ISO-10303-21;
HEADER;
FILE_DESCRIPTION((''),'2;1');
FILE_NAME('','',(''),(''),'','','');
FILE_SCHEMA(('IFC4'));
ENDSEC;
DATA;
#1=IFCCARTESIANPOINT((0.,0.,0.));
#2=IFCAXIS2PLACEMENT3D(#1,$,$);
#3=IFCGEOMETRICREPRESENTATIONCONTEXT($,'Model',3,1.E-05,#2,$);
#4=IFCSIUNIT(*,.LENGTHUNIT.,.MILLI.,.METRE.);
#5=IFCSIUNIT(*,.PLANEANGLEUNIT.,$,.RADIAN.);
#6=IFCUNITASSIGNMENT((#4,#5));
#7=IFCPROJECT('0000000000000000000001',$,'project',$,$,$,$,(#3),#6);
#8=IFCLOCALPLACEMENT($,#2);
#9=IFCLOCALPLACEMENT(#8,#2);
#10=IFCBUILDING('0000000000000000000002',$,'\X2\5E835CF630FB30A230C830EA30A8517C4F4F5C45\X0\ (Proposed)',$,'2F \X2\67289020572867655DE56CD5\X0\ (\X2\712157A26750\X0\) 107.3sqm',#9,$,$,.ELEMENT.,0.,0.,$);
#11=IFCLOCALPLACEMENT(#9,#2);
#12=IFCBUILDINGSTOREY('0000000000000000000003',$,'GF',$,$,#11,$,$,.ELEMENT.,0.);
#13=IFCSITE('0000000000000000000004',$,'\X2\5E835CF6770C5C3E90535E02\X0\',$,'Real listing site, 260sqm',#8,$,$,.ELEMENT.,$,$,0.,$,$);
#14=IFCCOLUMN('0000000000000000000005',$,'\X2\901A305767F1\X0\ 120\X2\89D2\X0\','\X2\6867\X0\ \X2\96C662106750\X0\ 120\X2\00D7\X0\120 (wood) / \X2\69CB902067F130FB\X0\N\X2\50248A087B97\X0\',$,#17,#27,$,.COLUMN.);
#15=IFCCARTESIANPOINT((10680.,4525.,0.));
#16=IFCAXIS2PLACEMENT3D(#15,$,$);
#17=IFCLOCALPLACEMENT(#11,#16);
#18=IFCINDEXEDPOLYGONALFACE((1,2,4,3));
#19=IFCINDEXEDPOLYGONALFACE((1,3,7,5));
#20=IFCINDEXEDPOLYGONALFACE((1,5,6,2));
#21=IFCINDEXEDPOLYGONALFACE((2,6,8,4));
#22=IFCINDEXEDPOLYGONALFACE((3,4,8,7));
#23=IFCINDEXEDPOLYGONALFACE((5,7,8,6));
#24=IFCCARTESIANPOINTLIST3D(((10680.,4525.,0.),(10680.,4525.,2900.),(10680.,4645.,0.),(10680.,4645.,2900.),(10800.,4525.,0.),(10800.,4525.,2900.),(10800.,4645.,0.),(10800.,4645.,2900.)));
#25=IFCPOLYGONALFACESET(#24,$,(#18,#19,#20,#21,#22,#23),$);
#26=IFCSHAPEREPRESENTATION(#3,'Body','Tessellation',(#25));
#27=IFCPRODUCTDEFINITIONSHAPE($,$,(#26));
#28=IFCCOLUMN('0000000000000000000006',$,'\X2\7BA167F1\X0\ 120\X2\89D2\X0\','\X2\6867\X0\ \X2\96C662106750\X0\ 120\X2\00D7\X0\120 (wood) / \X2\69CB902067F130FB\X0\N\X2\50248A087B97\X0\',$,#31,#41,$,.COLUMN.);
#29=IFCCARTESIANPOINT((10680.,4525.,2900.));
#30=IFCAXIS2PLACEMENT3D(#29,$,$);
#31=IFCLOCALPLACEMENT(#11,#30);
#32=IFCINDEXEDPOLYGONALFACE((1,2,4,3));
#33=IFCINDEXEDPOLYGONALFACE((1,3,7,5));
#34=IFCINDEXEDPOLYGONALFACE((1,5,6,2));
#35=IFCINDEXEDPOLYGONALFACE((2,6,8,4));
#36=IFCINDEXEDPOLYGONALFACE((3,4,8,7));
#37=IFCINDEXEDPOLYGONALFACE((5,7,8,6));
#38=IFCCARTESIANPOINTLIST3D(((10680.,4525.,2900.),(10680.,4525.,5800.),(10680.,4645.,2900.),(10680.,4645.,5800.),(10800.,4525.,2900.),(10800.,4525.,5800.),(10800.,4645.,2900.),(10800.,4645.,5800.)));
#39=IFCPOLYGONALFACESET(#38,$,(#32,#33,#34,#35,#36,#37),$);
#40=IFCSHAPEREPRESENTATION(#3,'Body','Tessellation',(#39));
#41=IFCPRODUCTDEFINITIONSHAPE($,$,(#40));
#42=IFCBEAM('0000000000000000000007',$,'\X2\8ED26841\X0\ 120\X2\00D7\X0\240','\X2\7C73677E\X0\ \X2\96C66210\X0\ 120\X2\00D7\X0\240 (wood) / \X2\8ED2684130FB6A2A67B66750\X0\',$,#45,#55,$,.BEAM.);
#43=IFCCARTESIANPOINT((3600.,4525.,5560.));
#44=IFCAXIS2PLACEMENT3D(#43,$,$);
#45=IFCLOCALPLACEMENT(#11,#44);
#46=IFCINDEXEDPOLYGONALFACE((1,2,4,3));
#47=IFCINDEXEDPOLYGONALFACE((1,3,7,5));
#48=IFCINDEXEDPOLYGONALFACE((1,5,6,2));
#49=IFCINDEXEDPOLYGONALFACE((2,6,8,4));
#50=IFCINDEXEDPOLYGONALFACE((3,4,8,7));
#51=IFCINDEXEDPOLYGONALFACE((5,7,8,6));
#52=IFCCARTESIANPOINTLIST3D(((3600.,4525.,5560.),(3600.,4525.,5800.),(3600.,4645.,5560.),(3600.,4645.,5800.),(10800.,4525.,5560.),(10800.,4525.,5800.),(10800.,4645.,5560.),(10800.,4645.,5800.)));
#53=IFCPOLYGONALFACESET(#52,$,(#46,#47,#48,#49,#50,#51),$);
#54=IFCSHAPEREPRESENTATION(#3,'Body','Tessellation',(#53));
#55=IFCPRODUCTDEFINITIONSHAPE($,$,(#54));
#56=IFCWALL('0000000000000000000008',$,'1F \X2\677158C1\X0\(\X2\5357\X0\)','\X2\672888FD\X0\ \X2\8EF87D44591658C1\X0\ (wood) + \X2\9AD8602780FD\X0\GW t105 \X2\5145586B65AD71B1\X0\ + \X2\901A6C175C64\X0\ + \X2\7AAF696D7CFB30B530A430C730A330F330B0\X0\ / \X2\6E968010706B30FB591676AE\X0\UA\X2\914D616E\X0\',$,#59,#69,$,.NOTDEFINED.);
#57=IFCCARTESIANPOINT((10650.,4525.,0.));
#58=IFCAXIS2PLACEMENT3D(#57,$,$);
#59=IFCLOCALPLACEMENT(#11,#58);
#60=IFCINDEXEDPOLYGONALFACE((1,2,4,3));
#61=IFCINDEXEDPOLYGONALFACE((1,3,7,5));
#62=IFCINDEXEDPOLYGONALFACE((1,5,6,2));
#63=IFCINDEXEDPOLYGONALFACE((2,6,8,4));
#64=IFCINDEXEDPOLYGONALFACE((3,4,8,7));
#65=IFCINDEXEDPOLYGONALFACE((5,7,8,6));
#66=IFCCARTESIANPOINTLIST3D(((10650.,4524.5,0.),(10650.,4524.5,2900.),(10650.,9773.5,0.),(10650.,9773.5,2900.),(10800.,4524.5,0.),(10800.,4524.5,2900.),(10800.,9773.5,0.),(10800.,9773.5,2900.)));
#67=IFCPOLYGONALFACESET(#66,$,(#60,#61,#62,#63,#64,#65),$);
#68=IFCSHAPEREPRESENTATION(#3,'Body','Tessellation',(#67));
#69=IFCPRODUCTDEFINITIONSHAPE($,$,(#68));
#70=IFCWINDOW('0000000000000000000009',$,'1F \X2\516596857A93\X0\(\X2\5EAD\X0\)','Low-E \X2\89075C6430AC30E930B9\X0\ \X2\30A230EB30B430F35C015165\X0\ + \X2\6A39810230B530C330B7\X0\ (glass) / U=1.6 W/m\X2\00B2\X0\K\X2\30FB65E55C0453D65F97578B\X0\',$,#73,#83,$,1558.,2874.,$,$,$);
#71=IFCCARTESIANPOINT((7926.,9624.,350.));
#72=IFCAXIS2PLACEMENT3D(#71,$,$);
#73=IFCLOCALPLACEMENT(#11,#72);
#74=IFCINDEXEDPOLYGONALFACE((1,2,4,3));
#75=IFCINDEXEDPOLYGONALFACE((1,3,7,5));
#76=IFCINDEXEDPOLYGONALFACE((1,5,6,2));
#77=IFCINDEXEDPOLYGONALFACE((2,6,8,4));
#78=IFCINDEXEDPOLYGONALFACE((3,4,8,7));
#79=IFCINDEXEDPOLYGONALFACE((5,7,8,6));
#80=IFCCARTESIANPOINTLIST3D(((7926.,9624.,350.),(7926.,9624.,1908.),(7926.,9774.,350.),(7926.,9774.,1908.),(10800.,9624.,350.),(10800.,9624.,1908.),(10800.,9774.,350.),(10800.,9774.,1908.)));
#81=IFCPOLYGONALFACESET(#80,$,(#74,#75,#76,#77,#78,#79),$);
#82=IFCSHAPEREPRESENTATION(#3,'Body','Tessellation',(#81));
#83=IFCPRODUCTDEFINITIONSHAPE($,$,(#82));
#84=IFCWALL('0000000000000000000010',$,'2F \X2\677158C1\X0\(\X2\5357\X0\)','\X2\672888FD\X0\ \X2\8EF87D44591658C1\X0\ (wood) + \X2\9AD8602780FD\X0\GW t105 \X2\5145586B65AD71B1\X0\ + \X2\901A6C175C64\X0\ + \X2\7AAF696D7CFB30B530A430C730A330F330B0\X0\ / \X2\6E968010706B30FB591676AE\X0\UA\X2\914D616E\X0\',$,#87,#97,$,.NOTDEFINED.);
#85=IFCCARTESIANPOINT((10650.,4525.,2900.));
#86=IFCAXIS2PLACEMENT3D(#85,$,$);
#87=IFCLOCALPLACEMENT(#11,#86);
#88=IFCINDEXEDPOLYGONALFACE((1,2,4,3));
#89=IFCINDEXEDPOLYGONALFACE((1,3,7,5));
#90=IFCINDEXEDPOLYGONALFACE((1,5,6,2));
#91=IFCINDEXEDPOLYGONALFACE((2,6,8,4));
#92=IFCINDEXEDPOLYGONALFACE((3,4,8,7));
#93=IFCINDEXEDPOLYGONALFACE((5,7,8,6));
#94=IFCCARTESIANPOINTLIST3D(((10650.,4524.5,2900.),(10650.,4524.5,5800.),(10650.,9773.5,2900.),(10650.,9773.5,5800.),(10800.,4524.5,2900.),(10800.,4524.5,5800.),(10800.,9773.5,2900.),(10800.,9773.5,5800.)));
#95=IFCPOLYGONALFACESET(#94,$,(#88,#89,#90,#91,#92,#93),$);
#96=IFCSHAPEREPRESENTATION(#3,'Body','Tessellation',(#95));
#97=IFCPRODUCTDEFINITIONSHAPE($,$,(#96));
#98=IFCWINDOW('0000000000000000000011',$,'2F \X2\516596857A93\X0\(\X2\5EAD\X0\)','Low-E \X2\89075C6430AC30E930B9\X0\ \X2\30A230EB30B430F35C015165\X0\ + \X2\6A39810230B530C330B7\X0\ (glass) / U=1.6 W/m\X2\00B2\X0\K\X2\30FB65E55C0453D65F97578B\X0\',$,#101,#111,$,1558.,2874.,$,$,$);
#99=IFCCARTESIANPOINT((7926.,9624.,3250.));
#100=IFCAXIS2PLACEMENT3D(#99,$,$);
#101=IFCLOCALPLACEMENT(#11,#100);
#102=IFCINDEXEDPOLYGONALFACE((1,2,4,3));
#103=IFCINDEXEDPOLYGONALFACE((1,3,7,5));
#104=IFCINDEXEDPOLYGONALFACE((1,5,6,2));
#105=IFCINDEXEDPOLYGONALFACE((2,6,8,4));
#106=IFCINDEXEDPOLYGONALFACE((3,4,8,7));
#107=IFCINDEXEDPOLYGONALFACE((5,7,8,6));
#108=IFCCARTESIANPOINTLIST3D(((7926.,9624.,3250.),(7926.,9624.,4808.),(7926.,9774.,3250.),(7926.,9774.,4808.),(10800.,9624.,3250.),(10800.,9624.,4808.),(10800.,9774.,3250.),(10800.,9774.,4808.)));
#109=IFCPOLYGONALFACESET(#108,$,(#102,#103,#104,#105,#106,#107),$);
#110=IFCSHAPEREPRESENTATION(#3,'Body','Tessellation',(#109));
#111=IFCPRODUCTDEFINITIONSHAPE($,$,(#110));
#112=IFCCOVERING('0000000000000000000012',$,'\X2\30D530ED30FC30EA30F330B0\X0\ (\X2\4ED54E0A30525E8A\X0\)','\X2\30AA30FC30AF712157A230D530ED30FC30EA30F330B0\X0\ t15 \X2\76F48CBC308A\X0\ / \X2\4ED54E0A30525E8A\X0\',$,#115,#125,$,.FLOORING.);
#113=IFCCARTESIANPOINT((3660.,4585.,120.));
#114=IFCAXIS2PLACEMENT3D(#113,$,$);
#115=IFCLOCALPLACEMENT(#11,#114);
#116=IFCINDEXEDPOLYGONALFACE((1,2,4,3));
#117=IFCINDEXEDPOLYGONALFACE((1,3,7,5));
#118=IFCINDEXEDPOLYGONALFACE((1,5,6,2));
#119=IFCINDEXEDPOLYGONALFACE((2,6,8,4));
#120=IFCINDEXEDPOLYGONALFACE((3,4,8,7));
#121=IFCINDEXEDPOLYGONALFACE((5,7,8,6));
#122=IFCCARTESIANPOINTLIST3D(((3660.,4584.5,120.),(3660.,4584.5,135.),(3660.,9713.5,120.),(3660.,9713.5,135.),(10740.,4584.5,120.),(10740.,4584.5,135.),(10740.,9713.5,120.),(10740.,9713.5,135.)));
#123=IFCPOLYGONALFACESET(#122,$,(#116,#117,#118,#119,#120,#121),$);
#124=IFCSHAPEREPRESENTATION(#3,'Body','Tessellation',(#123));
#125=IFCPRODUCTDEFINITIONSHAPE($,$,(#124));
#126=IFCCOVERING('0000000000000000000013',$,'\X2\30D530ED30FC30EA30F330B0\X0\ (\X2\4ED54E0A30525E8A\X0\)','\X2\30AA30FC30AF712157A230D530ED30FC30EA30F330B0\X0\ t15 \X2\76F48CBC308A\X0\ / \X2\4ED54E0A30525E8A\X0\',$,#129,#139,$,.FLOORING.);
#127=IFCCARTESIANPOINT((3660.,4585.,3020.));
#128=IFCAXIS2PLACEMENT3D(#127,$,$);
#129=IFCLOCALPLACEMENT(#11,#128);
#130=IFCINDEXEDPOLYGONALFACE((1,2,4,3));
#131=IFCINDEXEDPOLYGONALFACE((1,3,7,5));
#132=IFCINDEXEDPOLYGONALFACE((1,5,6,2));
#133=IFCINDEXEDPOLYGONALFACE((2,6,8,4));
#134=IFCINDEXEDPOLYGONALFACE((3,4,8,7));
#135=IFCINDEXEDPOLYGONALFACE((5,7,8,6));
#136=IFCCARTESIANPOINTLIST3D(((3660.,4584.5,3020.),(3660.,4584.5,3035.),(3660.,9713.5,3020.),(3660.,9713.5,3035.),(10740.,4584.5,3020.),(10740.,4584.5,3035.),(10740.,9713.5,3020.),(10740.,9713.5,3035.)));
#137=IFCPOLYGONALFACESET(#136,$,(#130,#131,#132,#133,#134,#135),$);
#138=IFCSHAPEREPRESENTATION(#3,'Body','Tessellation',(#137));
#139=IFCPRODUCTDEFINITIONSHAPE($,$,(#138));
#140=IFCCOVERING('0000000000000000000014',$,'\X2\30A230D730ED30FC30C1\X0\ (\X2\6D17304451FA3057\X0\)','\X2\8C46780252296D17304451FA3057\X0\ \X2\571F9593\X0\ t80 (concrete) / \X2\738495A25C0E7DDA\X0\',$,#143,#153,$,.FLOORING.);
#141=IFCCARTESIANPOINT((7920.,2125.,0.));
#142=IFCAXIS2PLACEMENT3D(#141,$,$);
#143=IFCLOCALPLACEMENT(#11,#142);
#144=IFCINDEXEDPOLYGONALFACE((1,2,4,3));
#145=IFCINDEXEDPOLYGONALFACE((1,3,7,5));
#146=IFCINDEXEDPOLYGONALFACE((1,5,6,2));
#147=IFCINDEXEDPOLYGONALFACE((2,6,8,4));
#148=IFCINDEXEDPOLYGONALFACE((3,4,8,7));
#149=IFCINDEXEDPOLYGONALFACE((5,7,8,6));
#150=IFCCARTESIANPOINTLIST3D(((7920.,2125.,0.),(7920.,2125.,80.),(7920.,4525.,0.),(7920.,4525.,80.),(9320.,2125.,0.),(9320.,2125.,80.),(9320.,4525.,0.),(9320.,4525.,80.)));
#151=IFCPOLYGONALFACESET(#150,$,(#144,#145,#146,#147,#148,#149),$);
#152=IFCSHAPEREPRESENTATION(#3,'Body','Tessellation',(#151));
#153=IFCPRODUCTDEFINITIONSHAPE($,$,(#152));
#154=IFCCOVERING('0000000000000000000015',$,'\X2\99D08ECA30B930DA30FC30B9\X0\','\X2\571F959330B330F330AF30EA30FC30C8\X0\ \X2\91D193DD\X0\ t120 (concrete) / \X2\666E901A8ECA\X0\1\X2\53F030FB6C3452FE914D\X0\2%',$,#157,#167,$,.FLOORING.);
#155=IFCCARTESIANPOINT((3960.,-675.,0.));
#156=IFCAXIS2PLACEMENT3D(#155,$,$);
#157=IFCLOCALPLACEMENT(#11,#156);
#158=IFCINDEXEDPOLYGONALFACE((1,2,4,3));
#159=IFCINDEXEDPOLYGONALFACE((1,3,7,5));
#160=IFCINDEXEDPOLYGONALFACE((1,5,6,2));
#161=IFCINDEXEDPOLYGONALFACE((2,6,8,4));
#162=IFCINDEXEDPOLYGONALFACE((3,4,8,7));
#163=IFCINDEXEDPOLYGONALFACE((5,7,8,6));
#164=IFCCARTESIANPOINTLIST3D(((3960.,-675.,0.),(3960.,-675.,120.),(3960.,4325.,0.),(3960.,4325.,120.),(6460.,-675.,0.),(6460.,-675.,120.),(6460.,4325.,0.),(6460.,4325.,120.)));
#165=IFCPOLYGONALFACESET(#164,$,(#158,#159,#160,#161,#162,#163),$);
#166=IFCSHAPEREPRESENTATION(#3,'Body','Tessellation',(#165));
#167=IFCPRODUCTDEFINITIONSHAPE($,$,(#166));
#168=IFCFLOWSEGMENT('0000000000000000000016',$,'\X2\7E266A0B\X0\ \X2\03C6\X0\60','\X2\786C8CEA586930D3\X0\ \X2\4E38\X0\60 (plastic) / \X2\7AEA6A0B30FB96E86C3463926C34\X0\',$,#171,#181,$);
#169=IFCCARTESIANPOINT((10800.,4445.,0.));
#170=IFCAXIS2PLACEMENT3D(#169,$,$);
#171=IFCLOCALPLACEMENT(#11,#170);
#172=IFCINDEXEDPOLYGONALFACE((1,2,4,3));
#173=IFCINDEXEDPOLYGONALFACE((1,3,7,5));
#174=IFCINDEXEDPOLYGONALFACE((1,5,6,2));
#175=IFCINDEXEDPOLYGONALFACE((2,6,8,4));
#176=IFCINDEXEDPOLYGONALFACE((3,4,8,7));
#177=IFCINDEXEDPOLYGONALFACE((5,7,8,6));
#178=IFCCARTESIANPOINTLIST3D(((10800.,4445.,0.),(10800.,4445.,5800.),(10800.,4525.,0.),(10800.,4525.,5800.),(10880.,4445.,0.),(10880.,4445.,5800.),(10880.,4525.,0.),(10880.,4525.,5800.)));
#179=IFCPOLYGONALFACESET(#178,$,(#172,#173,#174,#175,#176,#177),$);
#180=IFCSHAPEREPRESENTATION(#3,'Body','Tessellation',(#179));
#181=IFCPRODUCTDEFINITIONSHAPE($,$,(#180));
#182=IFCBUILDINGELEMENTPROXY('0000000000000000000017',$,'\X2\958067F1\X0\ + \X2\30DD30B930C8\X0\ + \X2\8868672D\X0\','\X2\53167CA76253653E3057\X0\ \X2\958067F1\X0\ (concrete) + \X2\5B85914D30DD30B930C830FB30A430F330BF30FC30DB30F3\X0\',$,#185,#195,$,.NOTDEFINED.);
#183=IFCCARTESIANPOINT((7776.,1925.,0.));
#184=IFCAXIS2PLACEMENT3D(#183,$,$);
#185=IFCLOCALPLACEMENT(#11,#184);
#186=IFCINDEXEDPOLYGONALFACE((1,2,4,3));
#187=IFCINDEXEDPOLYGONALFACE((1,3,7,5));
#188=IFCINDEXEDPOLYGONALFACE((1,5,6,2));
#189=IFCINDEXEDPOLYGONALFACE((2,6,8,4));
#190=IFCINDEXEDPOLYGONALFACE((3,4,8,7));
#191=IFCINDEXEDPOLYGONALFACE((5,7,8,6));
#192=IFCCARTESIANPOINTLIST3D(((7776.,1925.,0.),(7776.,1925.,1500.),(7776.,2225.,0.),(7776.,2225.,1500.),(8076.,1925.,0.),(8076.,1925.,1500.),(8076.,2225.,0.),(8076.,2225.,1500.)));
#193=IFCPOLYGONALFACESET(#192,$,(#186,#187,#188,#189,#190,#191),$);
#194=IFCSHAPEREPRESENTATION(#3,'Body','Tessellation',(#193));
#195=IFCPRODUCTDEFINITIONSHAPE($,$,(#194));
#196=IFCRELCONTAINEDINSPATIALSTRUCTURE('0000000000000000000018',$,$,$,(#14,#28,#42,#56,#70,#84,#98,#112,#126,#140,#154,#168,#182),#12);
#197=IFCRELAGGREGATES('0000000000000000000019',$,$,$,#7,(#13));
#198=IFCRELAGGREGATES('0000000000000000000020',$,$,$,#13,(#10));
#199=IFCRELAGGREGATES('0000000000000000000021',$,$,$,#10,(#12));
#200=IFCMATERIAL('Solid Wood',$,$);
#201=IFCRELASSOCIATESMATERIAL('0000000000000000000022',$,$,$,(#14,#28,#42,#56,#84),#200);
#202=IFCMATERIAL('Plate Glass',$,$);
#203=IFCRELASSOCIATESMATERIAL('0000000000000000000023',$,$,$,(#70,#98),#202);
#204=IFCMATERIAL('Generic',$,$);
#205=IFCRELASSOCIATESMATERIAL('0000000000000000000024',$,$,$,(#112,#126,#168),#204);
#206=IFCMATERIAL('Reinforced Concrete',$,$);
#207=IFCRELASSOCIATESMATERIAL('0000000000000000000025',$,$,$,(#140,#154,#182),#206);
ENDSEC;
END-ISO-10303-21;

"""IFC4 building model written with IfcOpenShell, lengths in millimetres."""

from ifc_helpers import new_model, si_unit, frame, frame_2d, origin, place, context, project, spatial, rectangle, extrude, material, element, fill, save


model = new_model("IFC4")

# Units and contexts
model_context = context("Model", 3, precision=1e-05, world=origin())
ifc_project = project(units=[si_unit("LENGTHUNIT", "METRE", prefix="MILLI"), si_unit("PLANEANGLEUNIT", "RADIAN")], contexts=[model_context])

# Site, building, storey
site_placement = place(None, origin())
site = spatial("IfcSite", under=ifc_project, at=site_placement, Name="広島県尾道市", ObjectType="Real listing site, 260sqm", CompositionType="ELEMENT", RefElevation=0.0)
building_placement = place(site_placement, origin())
building = spatial("IfcBuilding", under=site, at=building_placement, Name="広島・アトリエ兼住居 (Proposed)", ObjectType="2F 木造在来工法 (無垢材) 107.3sqm", CompositionType="ELEMENT", ElevationOfRefHeight=0.0, ElevationOfTerrain=0.0)
storey_placement = place(building_placement, origin())
storey = spatial("IfcBuildingStorey", under=building, at=storey_placement, Name="GF", CompositionType="ELEMENT", Elevation=0.0)

# Columns
ifc_material_1 = material(Name="Solid Wood")
column_1_placement = place(storey_placement, frame((10680.0, 4525.0, 0.0)))
element("IfcColumn", 1, at=column_1_placement, inside=storey, material=ifc_material_1, Name="通し柱 120角", Description="桧 集成材 120×120 (wood) / 構造柱・N値計算", PredefinedType="COLUMN", context=model_context, shape_type="SweptSolid", body=[
    extrude(rectangle(XDim=120.0, YDim=120.0, at=frame_2d((60.0, 60.0))), frame((10680.0, 4525.0, 0.0)), (0.0, 0.0, 1.0), 2900.0),
])
column_2_placement = place(storey_placement, frame((10680.0, 4525.0, 2900.0)))
element("IfcColumn", 2, at=column_2_placement, inside=storey, material=ifc_material_1, Name="管柱 120角", Description="桧 集成材 120×120 (wood) / 構造柱・N値計算", PredefinedType="COLUMN", context=model_context, shape_type="SweptSolid", body=[
    extrude(rectangle(XDim=120.0, YDim=120.0, at=frame_2d((60.0, 60.0))), frame((10680.0, 4525.0, 2900.0)), (0.0, 0.0, 1.0), 2900.0),
])

# Beam
beam_1_placement = place(storey_placement, frame((3600.0, 4525.0, 5560.0)))
element("IfcBeam", 3, at=beam_1_placement, inside=storey, material=ifc_material_1, Name="軒桁 120×240", Description="米松 集成 120×240 (wood) / 軒桁・横架材", PredefinedType="BEAM", context=model_context, shape_type="SweptSolid", body=[
    extrude(rectangle(XDim=7200.0, YDim=120.0, at=frame_2d((3600.0, 60.0))), frame((3600.0, 4525.0, 5560.0)), (0.0, 0.0, 1.0), 240.0),
])

# Wall, opening, window
wall_1_placement = place(storey_placement, frame((10650.0, 4525.0, 0.0)))
wall_1 = element("IfcWall", 4, at=wall_1_placement, inside=storey, material=ifc_material_1, Name="1F 東壁(南)", Description="木製 軸組外壁 (wood) + 高性能GW t105 充填断熱 + 通気層 + 窯業系サイディング / 準耐火・外皮UA配慮", PredefinedType="NOTDEFINED", context=model_context, shape_type="SweptSolid", body=[
    extrude(rectangle(XDim=150.0, YDim=5249.0, at=frame_2d((75.0, 2624.0))), frame((10650.0, 4525.0, 0.0)), (0.0, 0.0, 1.0), 2900.0),
])
opening_1_placement = place(storey_placement, frame((7926.0, 9624.0, 350.0)))
opening_1 = element("IfcOpeningElement", 5, at=opening_1_placement, cuts=wall_1, PredefinedType="NOTDEFINED", context=model_context, shape_type="SweptSolid", body=[
    extrude(rectangle(XDim=2874.0, YDim=150.0, at=frame_2d((1437.0, 75.0))), frame((7926.0, 9624.0, 350.0)), (0.0, 0.0, 1.0), 1558.0),
])
ifc_material_2 = material(Name="Plate Glass")
window_1_placement = place(storey_placement, frame((7926.0, 9624.0, 350.0)))
window_1 = element("IfcWindow", 6, at=window_1_placement, inside=storey, material=ifc_material_2, Name="1F 入隅窓(庭)", Description="Low-E 複層ガラス アルゴン封入 + 樹脂サッシ (glass) / U=1.6 W/m²K・日射取得型", OverallHeight=1558.0, OverallWidth=2874.0, context=model_context, shape_type="SweptSolid", body=[
    extrude(rectangle(XDim=2874.0, YDim=150.0, at=frame_2d((1437.0, 75.0))), frame((7926.0, 9624.0, 350.0)), (0.0, 0.0, 1.0), 1558.0),
])
fill(opening_1, window_1)

# Wall, opening, window
wall_2_placement = place(storey_placement, frame((10650.0, 4525.0, 2900.0)))
wall_2 = element("IfcWall", 7, at=wall_2_placement, inside=storey, material=ifc_material_1, Name="2F 東壁(南)", Description="木製 軸組外壁 (wood) + 高性能GW t105 充填断熱 + 通気層 + 窯業系サイディング / 準耐火・外皮UA配慮", PredefinedType="NOTDEFINED", context=model_context, shape_type="SweptSolid", body=[
    extrude(rectangle(XDim=150.0, YDim=5249.0, at=frame_2d((75.0, 2624.0))), frame((10650.0, 4525.0, 2900.0)), (0.0, 0.0, 1.0), 2900.0),
])
opening_2_placement = place(storey_placement, frame((7926.0, 9624.0, 3250.0)))
opening_2 = element("IfcOpeningElement", 8, at=opening_2_placement, cuts=wall_2, PredefinedType="NOTDEFINED", context=model_context, shape_type="SweptSolid", body=[
    extrude(rectangle(XDim=2874.0, YDim=150.0, at=frame_2d((1437.0, 75.0))), frame((7926.0, 9624.0, 3250.0)), (0.0, 0.0, 1.0), 1558.0),
])
window_2_placement = place(storey_placement, frame((7926.0, 9624.0, 3250.0)))
window_2 = element("IfcWindow", 9, at=window_2_placement, inside=storey, material=ifc_material_2, Name="2F 入隅窓(庭)", Description="Low-E 複層ガラス アルゴン封入 + 樹脂サッシ (glass) / U=1.6 W/m²K・日射取得型", OverallHeight=1558.0, OverallWidth=2874.0, context=model_context, shape_type="SweptSolid", body=[
    extrude(rectangle(XDim=2874.0, YDim=150.0, at=frame_2d((1437.0, 75.0))), frame((7926.0, 9624.0, 3250.0)), (0.0, 0.0, 1.0), 1558.0),
])
fill(opening_2, window_2)

# Coverings
ifc_material_3 = material(Name="Generic")
covering_1_placement = place(storey_placement, frame((3660.0, 4585.0, 120.0)))
element("IfcCovering", 10, at=covering_1_placement, inside=storey, material=ifc_material_3, Name="フローリング (仕上げ床)", Description="オーク無垢フローリング t15 直貼り / 仕上げ床", PredefinedType="FLOORING", context=model_context, shape_type="SweptSolid", body=[
    extrude(rectangle(XDim=7080.0, YDim=5129.0, at=frame_2d((3540.0, 2564.0))), frame((3660.0, 4585.0, 120.0)), (0.0, 0.0, 1.0), 15.0),
])
covering_2_placement = place(storey_placement, frame((3660.0, 4585.0, 3020.0)))
element("IfcCovering", 11, at=covering_2_placement, inside=storey, material=ifc_material_3, Name="フローリング (仕上げ床)", Description="オーク無垢フローリング t15 直貼り / 仕上げ床", PredefinedType="FLOORING", context=model_context, shape_type="SweptSolid", body=[
    extrude(rectangle(XDim=7080.0, YDim=5129.0, at=frame_2d((3540.0, 2564.0))), frame((3660.0, 4585.0, 3020.0)), (0.0, 0.0, 1.0), 15.0),
])
ifc_material_4 = material(Name="Reinforced Concrete")
covering_3_placement = place(storey_placement, frame((7920.0, 2125.0, 0.0)))
element("IfcCovering", 12, at=covering_3_placement, inside=storey, material=ifc_material_4, Name="アプローチ (洗い出し)", Description="豆砂利洗い出し 土間 t80 (concrete) / 玄関導線", PredefinedType="FLOORING", context=model_context, shape_type="SweptSolid", body=[
    extrude(rectangle(XDim=1400.0, YDim=2400.0, at=frame_2d((700.0, 1200.0))), frame((7920.0, 2125.0, 0.0)), (0.0, 0.0, 1.0), 80.0),
])
covering_4_placement = place(storey_placement, frame((3960.0, -675.0, 0.0)))
element("IfcCovering", 13, at=covering_4_placement, inside=storey, material=ifc_material_4, Name="駐車スペース", Description="土間コンクリート 金鏝 t120 (concrete) / 普通車1台・水勾配2%", PredefinedType="FLOORING", context=model_context, shape_type="SweptSolid", body=[
    extrude(rectangle(XDim=2500.0, YDim=5000.0, at=frame_2d((1250.0, 2500.0))), frame((3960.0, -675.0, 0.0)), (0.0, 0.0, 1.0), 120.0),
])

# Flow segment
flow_segment_placement = place(storey_placement, frame((10800.0, 4445.0, 0.0)))
element("IfcFlowSegment", 14, at=flow_segment_placement, inside=storey, material=ifc_material_3, Name="縦樋 φ60", Description="硬質塩ビ 丸60 (plastic) / 竪樋・雨水排水", context=model_context, shape_type="SweptSolid", body=[
    extrude(rectangle(XDim=80.0, YDim=80.0, at=frame_2d((40.0, 40.0))), frame((10800.0, 4445.0, 0.0)), (0.0, 0.0, 1.0), 5800.0),
])

# Building element proxy
proxy_placement = place(storey_placement, frame((7776.0, 1925.0, 0.0)))
element("IfcBuildingElementProxy", 15, at=proxy_placement, inside=storey, material=ifc_material_4, Name="門柱 + ポスト + 表札", Description="化粧打放し 門柱 (concrete) + 宅配ポスト・インターホン", PredefinedType="NOTDEFINED", context=model_context, shape_type="SweptSolid", body=[
    extrude(rectangle(XDim=300.0, YDim=300.0, at=frame_2d((150.0, 150.0))), frame((7776.0, 1925.0, 0.0)), (0.0, 0.0, 1.0), 1500.0),
])

save(model, "model.ifc")
